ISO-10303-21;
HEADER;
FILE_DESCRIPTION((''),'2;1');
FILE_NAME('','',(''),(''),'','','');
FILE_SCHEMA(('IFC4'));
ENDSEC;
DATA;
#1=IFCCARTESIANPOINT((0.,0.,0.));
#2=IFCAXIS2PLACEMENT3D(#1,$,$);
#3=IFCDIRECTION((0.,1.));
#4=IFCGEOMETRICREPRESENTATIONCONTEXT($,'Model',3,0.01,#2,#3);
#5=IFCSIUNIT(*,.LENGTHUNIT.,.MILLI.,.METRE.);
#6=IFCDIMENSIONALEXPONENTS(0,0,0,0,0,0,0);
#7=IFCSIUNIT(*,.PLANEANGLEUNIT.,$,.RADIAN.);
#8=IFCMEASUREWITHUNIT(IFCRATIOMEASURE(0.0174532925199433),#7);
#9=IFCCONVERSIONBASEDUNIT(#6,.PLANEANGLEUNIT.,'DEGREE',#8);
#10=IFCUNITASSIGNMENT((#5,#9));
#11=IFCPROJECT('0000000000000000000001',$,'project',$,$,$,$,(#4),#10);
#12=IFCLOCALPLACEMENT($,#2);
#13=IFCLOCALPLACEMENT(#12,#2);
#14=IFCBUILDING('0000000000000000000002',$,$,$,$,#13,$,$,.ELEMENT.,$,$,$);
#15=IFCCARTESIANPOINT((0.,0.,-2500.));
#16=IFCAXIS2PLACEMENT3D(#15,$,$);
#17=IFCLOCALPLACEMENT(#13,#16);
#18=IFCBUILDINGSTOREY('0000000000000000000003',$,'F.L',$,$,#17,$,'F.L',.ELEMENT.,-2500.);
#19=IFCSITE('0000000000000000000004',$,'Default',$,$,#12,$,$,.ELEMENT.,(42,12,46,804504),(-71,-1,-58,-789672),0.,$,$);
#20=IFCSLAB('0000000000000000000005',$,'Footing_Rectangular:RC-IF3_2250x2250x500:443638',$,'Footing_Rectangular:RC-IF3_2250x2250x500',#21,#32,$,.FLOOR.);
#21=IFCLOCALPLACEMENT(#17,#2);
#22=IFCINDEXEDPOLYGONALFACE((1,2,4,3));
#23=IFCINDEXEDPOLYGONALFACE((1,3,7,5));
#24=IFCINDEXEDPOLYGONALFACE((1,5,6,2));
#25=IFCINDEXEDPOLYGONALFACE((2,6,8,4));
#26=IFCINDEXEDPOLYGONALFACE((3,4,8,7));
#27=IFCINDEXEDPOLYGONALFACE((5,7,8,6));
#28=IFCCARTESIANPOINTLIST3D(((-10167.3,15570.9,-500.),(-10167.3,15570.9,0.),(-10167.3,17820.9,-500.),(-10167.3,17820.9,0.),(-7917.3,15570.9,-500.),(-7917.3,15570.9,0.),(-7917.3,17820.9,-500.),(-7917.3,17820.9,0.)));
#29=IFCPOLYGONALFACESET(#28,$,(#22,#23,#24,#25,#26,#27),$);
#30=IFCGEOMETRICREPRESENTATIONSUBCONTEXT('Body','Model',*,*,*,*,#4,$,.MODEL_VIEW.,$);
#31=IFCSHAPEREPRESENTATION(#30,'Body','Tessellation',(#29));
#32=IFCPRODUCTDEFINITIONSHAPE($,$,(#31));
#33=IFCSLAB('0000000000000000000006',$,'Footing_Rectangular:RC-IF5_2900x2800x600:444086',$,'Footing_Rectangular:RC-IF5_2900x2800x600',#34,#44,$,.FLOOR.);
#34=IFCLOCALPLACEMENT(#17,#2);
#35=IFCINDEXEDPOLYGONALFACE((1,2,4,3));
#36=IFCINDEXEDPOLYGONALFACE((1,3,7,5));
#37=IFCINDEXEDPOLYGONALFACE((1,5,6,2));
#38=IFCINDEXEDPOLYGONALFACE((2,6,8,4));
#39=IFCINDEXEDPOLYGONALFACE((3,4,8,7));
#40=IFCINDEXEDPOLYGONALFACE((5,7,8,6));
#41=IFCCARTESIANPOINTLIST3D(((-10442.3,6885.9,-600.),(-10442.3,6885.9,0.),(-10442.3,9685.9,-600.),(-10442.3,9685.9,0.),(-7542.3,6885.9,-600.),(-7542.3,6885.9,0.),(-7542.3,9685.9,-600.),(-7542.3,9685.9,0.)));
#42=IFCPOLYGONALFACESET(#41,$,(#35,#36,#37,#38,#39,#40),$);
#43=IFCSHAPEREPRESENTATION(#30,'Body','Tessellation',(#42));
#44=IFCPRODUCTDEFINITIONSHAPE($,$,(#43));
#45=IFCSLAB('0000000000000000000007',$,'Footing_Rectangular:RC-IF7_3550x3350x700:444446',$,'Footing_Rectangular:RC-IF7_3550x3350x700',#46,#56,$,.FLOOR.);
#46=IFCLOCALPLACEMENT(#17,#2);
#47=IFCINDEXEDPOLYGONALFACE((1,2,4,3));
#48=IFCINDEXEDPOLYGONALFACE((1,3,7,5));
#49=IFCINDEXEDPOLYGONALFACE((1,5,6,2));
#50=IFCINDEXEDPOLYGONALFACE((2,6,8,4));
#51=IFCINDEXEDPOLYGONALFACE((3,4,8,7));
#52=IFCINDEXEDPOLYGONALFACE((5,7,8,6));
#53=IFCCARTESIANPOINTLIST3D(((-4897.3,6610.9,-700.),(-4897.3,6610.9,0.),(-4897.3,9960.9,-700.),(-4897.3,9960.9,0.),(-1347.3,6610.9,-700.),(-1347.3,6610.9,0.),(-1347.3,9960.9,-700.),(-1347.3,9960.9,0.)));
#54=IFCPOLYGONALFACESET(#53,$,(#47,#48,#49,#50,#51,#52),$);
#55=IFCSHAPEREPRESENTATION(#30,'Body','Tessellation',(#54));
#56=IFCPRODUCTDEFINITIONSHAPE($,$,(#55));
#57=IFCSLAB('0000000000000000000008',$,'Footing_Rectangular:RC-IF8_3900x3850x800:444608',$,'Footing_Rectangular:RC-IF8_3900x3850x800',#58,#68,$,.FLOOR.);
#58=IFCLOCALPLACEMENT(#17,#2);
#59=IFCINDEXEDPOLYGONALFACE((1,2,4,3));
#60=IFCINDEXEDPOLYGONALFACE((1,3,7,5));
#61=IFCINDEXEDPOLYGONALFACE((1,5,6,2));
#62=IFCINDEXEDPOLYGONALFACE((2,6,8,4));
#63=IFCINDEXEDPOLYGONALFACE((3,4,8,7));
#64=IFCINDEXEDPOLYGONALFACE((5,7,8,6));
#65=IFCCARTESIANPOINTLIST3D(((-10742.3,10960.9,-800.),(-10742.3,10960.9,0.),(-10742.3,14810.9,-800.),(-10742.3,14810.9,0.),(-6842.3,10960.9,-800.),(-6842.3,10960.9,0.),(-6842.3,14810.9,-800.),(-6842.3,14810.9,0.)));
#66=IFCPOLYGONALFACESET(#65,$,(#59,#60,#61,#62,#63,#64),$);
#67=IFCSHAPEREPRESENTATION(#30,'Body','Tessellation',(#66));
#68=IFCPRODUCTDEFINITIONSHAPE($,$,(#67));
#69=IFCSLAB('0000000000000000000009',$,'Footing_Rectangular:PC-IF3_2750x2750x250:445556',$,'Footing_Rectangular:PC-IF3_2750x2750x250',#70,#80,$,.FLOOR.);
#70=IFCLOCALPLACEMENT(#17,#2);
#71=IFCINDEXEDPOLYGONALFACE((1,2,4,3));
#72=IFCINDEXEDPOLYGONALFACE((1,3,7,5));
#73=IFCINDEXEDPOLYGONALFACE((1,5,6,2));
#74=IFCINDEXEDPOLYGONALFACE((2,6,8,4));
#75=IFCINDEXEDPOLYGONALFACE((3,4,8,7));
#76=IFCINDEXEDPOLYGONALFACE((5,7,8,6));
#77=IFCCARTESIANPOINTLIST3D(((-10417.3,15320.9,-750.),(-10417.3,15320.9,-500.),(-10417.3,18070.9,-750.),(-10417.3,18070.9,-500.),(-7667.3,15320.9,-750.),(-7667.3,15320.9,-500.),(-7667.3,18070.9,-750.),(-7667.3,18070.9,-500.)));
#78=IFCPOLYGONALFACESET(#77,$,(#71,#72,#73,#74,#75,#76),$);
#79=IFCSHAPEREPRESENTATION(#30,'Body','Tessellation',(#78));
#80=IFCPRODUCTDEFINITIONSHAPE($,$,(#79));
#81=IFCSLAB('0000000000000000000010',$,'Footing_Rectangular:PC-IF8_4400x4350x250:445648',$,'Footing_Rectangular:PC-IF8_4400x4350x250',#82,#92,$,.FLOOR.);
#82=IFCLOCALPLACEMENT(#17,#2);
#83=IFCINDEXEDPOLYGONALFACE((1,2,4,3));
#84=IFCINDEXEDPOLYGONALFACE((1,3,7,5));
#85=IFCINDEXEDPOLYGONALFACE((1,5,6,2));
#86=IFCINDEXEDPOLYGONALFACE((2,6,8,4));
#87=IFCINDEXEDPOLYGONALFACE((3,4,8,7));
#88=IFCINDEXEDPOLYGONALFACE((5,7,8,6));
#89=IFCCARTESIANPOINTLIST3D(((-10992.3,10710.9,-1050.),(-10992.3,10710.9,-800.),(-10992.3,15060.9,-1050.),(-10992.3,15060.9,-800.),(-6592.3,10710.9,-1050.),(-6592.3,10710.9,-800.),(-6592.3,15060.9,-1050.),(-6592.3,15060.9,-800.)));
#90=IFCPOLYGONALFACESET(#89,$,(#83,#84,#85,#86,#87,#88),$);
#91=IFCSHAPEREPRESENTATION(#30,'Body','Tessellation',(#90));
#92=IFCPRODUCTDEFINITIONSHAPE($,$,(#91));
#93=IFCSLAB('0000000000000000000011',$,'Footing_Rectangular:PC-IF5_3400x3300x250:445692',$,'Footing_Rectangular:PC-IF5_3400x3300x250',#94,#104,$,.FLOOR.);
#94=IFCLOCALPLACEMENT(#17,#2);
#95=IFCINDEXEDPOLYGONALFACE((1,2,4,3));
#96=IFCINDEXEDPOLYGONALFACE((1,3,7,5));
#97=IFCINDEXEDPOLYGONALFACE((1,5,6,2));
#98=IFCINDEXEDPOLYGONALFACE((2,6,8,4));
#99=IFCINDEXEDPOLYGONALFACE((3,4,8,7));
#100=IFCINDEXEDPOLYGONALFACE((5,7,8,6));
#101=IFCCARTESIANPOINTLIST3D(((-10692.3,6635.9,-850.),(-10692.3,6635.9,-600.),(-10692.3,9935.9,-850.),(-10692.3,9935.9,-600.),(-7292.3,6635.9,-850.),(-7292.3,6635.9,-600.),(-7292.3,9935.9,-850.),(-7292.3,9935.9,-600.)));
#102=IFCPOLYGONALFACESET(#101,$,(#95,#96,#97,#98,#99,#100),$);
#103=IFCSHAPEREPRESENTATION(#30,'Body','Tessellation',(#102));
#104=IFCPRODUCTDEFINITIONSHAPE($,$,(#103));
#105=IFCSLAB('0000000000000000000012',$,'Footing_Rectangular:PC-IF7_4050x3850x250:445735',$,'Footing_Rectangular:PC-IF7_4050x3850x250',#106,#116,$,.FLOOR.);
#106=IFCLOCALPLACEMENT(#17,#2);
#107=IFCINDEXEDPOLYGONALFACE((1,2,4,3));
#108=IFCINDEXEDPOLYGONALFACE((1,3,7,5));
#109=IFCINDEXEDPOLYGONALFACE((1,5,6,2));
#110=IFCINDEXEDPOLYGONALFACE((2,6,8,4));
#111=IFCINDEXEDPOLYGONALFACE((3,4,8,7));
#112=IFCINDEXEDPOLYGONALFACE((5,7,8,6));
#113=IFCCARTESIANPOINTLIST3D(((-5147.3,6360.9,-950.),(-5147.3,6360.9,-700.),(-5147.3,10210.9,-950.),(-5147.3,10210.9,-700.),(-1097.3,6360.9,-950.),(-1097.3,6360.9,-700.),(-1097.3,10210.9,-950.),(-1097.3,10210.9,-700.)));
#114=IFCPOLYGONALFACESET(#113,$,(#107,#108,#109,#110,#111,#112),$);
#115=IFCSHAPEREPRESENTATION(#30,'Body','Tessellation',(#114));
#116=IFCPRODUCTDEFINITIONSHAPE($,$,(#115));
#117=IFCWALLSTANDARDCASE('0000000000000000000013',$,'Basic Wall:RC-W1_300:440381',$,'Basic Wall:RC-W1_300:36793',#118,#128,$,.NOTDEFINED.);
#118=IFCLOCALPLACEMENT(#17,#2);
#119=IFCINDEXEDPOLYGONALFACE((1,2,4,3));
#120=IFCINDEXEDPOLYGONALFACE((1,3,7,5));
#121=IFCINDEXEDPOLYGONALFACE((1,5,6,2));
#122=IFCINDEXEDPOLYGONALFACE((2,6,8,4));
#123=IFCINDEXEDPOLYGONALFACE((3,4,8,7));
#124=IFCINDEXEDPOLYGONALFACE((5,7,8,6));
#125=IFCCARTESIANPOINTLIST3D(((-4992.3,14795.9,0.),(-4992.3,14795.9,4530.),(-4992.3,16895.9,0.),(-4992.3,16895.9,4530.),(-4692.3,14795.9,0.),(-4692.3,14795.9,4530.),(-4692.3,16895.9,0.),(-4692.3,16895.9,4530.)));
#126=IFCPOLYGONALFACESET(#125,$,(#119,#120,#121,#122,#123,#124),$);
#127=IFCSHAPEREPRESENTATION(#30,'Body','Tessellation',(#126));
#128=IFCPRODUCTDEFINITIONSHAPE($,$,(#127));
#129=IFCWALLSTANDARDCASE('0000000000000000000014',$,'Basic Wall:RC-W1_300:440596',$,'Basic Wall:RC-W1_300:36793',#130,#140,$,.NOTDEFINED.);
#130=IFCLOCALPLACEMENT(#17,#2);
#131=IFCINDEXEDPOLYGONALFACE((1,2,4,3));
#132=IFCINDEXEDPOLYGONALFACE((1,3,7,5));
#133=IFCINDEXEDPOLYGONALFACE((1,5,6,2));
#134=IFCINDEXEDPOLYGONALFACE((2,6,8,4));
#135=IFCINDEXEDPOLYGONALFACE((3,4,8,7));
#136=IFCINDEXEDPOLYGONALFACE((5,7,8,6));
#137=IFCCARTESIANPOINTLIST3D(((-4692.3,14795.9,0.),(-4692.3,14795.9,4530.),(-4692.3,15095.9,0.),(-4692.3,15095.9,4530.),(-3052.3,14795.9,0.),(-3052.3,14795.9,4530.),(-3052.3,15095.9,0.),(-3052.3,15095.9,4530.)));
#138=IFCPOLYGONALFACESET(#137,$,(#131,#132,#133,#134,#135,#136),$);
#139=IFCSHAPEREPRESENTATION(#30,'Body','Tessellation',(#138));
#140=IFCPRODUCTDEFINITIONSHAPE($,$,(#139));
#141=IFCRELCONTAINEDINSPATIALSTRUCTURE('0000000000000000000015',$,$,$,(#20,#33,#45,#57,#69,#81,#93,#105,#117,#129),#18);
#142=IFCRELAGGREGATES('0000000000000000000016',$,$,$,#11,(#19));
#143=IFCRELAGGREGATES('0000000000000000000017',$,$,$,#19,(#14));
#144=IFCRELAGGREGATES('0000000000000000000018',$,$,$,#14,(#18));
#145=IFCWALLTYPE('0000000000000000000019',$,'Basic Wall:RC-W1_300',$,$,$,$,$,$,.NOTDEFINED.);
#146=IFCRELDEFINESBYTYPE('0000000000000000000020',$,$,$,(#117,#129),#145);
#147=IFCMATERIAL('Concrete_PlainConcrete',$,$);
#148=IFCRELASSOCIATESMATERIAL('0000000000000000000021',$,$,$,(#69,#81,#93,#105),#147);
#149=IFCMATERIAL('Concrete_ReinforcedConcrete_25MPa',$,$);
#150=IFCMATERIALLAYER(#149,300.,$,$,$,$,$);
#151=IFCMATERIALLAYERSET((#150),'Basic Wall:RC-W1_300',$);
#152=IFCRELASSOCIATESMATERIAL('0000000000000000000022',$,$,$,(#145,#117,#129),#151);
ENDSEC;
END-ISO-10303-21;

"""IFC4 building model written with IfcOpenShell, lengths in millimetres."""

from ifc_helpers import new_model, entity, si_unit, converted_unit, direction, frame, frame_2d, origin, origin_2d_with_axis, place, context, subcontext, project, spatial, rectangle, extrude, material, layer, layer_set, layer_usage, type_object, element, save


model = new_model("IFC4")

# Units and contexts
model_context = context("Model", 3, precision=0.01, world=origin(), true_north=direction((0.0, 1.0)))
body_context = subcontext(model_context, "Body", "Model", "MODEL_VIEW")
ifc_project = project(units=[si_unit("LENGTHUNIT", "METRE", prefix="MILLI"), converted_unit("PLANEANGLEUNIT", "DEGREE", entity("IfcRatioMeasure", 0.0174532925199433), si_unit("PLANEANGLEUNIT", "RADIAN"), dimensions=[0, 0, 0, 0, 0, 0, 0])], contexts=[model_context])

# Site, building, storey
site_placement = place(None, origin())
site = spatial("IfcSite", under=ifc_project, at=site_placement, Name="Default", CompositionType="ELEMENT", RefLatitude=(42, 12, 46, 804504), RefLongitude=(-71, -1, -58, -789672), RefElevation=0.0)
building_placement = place(site_placement, origin())
building = spatial("IfcBuilding", under=site, at=building_placement, CompositionType="ELEMENT")
storey_placement = place(building_placement, frame((0.0, 0.0, -2500.0)))
storey = spatial("IfcBuildingStorey", under=building, at=storey_placement, Name="F.L", LongName="F.L", CompositionType="ELEMENT", Elevation=-2500.0)

# Shared definitions
ifc_material_1 = material(Name="Concrete_ReinforcedConcrete_25MPa")

# Slabs
slab_1_placement = place(storey_placement, frame((-10167.3, 15570.9, -500.0)))
element("IfcSlab", 1, at=slab_1_placement, inside=storey, Name="Footing_Rectangular:RC-IF3_2250x2250x500:443638", ObjectType="Footing_Rectangular:RC-IF3_2250x2250x500", PredefinedType="FLOOR", context=body_context, shape_type="SweptSolid", body=[
    extrude(rectangle(XDim=2250.0, YDim=2250.0, at=frame_2d((0.0, 0.0), x_axis=(1.0, 0.0))), frame((1125.0, 1125.0, 0.0)), (0.0, 0.0, 1.0), 500.0),
])
slab_2_placement = place(storey_placement, frame((-10442.3, 6885.9, -600.0)))
element("IfcSlab", 2, at=slab_2_placement, inside=storey, Name="Footing_Rectangular:RC-IF5_2900x2800x600:444086", ObjectType="Footing_Rectangular:RC-IF5_2900x2800x600", PredefinedType="FLOOR", context=body_context, shape_type="SweptSolid", body=[
    extrude(rectangle(XDim=2800.0, YDim=2900.0, at=frame_2d((0.0, 0.0), x_axis=(1.0, 0.0))), frame((1450.0, 1400.0, 0.0), z_axis=(0.0, 0.0, 1.0), x_axis=(0.0, 1.0, 0.0)), (0.0, 0.0, 1.0), 600.0),
])
slab_3_placement = place(storey_placement, frame((-4897.3, 6610.9, -700.0)))
element("IfcSlab", 3, at=slab_3_placement, inside=storey, Name="Footing_Rectangular:RC-IF7_3550x3350x700:444446", ObjectType="Footing_Rectangular:RC-IF7_3550x3350x700", PredefinedType="FLOOR", context=body_context, shape_type="SweptSolid", body=[
    extrude(rectangle(XDim=3350.0, YDim=3550.0, at=frame_2d((0.0, 0.0), x_axis=(1.0, 0.0))), frame((1775.0, 1675.0, 0.0), z_axis=(0.0, 0.0, 1.0), x_axis=(0.0, 1.0, 0.0)), (0.0, 0.0, 1.0), 700.0),
])
slab_4_placement = place(storey_placement, frame((-10742.3, 10960.9, -800.0)))
element("IfcSlab", 4, at=slab_4_placement, inside=storey, Name="Footing_Rectangular:RC-IF8_3900x3850x800:444608", ObjectType="Footing_Rectangular:RC-IF8_3900x3850x800", PredefinedType="FLOOR", context=body_context, shape_type="SweptSolid", body=[
    extrude(rectangle(XDim=3850.0, YDim=3900.0, at=frame_2d((0.0, 0.0), x_axis=(1.0, 0.0))), frame((1950.0, 1925.0, 0.0), z_axis=(0.0, 0.0, 1.0), x_axis=(0.0, 1.0, 0.0)), (0.0, 0.0, 1.0), 800.0),
])
ifc_material_2 = material(Name="Concrete_PlainConcrete")
slab_5_placement = place(storey_placement, frame((-10417.3, 15320.9, -750.0)))
element("IfcSlab", 5, at=slab_5_placement, inside=storey, material=ifc_material_2, Name="Footing_Rectangular:PC-IF3_2750x2750x250:445556", ObjectType="Footing_Rectangular:PC-IF3_2750x2750x250", PredefinedType="FLOOR", context=body_context, shape_type="SweptSolid", body=[
    extrude(rectangle(XDim=2750.0, YDim=2750.0, at=frame_2d((0.0, 0.0), x_axis=(1.0, 0.0))), frame((1375.0, 1375.0, 0.0)), (0.0, 0.0, 1.0), 250.0),
])
slab_6_placement = place(storey_placement, frame((-10992.3, 10710.9, -1050.0)))
element("IfcSlab", 6, at=slab_6_placement, inside=storey, material=ifc_material_2, Name="Footing_Rectangular:PC-IF8_4400x4350x250:445648", ObjectType="Footing_Rectangular:PC-IF8_4400x4350x250", PredefinedType="FLOOR", context=body_context, shape_type="SweptSolid", body=[
    extrude(rectangle(XDim=4350.0, YDim=4400.0, at=frame_2d((0.0, 0.0), x_axis=(1.0, 0.0))), frame((2200.0, 2175.0, 0.0), z_axis=(0.0, 0.0, 1.0), x_axis=(0.0, 1.0, 0.0)), (0.0, 0.0, 1.0), 250.0),
])
slab_7_placement = place(storey_placement, frame((-10692.3, 6635.9, -850.0)))
element("IfcSlab", 7, at=slab_7_placement, inside=storey, material=ifc_material_2, Name="Footing_Rectangular:PC-IF5_3400x3300x250:445692", ObjectType="Footing_Rectangular:PC-IF5_3400x3300x250", PredefinedType="FLOOR", context=body_context, shape_type="SweptSolid", body=[
    extrude(rectangle(XDim=3300.0, YDim=3400.0, at=origin_2d_with_axis()), frame((1700.0, 1650.0, 0.0), z_axis=(0.0, 0.0, 1.0), x_axis=(0.0, 1.0, 0.0)), (0.0, 0.0, 1.0), 250.0),
])
slab_8_placement = place(storey_placement, frame((-5147.3, 6360.9, -950.0)))
element("IfcSlab", 8, at=slab_8_placement, inside=storey, material=ifc_material_2, Name="Footing_Rectangular:PC-IF7_4050x3850x250:445735", ObjectType="Footing_Rectangular:PC-IF7_4050x3850x250", PredefinedType="FLOOR", context=body_context, shape_type="SweptSolid", body=[
    extrude(rectangle(XDim=3850.0, YDim=4050.0, at=origin_2d_with_axis()), frame((2025.0, 1925.0, 0.0), z_axis=(0.0, 0.0, 1.0), x_axis=(0.0, 1.0, 0.0)), (0.0, 0.0, 1.0), 250.0),
])

# Walls
ifc_layer = layer(ifc_material_1, 300.0)
ifc_layer_set = layer_set([ifc_layer], Name="Basic Wall:RC-W1_300")
ifc_layer_usage_1 = layer_usage(ifc_layer_set, "AXIS2", "NEGATIVE", 150.0)
wall_type = type_object("IfcWallType", Name="Basic Wall:RC-W1_300", PredefinedType="NOTDEFINED", material=ifc_layer_set)
wall_1_placement = place(storey_placement, frame((-4842.3, 16895.9, 0.0), z_axis=(0.0, 0.0, 1.0), x_axis=(0.0, -1.0, 0.0)))
element("IfcWallStandardCase", 9, at=wall_1_placement, inside=storey, type_object=wall_type, material=ifc_layer_usage_1, Name="Basic Wall:RC-W1_300:440381", ObjectType="Basic Wall:RC-W1_300:36793", PredefinedType="NOTDEFINED", context=body_context, shape_type="SweptSolid", body=[
    extrude(rectangle(XDim=2100.0, YDim=300.0, at=frame_2d((1050.0, 0.0), x_axis=(-1.0, 0.0))), origin(), (0.0, 0.0, 1.0), 4530.0),
])
ifc_layer_usage_2 = layer_usage(ifc_layer_set, "AXIS2", "NEGATIVE", 150.0)
wall_2_placement = place(storey_placement, frame((-4692.3, 14945.9, 0.0)))
element("IfcWallStandardCase", 10, at=wall_2_placement, inside=storey, type_object=wall_type, material=ifc_layer_usage_2, Name="Basic Wall:RC-W1_300:440596", ObjectType="Basic Wall:RC-W1_300:36793", PredefinedType="NOTDEFINED", context=body_context, shape_type="SweptSolid", body=[
    extrude(rectangle(XDim=1640.0, YDim=300.0, at=frame_2d((820.0, 0.0), x_axis=(-1.0, 0.0))), origin(), (0.0, 0.0, 1.0), 4530.0),
])

save(model, "model.ifc")
